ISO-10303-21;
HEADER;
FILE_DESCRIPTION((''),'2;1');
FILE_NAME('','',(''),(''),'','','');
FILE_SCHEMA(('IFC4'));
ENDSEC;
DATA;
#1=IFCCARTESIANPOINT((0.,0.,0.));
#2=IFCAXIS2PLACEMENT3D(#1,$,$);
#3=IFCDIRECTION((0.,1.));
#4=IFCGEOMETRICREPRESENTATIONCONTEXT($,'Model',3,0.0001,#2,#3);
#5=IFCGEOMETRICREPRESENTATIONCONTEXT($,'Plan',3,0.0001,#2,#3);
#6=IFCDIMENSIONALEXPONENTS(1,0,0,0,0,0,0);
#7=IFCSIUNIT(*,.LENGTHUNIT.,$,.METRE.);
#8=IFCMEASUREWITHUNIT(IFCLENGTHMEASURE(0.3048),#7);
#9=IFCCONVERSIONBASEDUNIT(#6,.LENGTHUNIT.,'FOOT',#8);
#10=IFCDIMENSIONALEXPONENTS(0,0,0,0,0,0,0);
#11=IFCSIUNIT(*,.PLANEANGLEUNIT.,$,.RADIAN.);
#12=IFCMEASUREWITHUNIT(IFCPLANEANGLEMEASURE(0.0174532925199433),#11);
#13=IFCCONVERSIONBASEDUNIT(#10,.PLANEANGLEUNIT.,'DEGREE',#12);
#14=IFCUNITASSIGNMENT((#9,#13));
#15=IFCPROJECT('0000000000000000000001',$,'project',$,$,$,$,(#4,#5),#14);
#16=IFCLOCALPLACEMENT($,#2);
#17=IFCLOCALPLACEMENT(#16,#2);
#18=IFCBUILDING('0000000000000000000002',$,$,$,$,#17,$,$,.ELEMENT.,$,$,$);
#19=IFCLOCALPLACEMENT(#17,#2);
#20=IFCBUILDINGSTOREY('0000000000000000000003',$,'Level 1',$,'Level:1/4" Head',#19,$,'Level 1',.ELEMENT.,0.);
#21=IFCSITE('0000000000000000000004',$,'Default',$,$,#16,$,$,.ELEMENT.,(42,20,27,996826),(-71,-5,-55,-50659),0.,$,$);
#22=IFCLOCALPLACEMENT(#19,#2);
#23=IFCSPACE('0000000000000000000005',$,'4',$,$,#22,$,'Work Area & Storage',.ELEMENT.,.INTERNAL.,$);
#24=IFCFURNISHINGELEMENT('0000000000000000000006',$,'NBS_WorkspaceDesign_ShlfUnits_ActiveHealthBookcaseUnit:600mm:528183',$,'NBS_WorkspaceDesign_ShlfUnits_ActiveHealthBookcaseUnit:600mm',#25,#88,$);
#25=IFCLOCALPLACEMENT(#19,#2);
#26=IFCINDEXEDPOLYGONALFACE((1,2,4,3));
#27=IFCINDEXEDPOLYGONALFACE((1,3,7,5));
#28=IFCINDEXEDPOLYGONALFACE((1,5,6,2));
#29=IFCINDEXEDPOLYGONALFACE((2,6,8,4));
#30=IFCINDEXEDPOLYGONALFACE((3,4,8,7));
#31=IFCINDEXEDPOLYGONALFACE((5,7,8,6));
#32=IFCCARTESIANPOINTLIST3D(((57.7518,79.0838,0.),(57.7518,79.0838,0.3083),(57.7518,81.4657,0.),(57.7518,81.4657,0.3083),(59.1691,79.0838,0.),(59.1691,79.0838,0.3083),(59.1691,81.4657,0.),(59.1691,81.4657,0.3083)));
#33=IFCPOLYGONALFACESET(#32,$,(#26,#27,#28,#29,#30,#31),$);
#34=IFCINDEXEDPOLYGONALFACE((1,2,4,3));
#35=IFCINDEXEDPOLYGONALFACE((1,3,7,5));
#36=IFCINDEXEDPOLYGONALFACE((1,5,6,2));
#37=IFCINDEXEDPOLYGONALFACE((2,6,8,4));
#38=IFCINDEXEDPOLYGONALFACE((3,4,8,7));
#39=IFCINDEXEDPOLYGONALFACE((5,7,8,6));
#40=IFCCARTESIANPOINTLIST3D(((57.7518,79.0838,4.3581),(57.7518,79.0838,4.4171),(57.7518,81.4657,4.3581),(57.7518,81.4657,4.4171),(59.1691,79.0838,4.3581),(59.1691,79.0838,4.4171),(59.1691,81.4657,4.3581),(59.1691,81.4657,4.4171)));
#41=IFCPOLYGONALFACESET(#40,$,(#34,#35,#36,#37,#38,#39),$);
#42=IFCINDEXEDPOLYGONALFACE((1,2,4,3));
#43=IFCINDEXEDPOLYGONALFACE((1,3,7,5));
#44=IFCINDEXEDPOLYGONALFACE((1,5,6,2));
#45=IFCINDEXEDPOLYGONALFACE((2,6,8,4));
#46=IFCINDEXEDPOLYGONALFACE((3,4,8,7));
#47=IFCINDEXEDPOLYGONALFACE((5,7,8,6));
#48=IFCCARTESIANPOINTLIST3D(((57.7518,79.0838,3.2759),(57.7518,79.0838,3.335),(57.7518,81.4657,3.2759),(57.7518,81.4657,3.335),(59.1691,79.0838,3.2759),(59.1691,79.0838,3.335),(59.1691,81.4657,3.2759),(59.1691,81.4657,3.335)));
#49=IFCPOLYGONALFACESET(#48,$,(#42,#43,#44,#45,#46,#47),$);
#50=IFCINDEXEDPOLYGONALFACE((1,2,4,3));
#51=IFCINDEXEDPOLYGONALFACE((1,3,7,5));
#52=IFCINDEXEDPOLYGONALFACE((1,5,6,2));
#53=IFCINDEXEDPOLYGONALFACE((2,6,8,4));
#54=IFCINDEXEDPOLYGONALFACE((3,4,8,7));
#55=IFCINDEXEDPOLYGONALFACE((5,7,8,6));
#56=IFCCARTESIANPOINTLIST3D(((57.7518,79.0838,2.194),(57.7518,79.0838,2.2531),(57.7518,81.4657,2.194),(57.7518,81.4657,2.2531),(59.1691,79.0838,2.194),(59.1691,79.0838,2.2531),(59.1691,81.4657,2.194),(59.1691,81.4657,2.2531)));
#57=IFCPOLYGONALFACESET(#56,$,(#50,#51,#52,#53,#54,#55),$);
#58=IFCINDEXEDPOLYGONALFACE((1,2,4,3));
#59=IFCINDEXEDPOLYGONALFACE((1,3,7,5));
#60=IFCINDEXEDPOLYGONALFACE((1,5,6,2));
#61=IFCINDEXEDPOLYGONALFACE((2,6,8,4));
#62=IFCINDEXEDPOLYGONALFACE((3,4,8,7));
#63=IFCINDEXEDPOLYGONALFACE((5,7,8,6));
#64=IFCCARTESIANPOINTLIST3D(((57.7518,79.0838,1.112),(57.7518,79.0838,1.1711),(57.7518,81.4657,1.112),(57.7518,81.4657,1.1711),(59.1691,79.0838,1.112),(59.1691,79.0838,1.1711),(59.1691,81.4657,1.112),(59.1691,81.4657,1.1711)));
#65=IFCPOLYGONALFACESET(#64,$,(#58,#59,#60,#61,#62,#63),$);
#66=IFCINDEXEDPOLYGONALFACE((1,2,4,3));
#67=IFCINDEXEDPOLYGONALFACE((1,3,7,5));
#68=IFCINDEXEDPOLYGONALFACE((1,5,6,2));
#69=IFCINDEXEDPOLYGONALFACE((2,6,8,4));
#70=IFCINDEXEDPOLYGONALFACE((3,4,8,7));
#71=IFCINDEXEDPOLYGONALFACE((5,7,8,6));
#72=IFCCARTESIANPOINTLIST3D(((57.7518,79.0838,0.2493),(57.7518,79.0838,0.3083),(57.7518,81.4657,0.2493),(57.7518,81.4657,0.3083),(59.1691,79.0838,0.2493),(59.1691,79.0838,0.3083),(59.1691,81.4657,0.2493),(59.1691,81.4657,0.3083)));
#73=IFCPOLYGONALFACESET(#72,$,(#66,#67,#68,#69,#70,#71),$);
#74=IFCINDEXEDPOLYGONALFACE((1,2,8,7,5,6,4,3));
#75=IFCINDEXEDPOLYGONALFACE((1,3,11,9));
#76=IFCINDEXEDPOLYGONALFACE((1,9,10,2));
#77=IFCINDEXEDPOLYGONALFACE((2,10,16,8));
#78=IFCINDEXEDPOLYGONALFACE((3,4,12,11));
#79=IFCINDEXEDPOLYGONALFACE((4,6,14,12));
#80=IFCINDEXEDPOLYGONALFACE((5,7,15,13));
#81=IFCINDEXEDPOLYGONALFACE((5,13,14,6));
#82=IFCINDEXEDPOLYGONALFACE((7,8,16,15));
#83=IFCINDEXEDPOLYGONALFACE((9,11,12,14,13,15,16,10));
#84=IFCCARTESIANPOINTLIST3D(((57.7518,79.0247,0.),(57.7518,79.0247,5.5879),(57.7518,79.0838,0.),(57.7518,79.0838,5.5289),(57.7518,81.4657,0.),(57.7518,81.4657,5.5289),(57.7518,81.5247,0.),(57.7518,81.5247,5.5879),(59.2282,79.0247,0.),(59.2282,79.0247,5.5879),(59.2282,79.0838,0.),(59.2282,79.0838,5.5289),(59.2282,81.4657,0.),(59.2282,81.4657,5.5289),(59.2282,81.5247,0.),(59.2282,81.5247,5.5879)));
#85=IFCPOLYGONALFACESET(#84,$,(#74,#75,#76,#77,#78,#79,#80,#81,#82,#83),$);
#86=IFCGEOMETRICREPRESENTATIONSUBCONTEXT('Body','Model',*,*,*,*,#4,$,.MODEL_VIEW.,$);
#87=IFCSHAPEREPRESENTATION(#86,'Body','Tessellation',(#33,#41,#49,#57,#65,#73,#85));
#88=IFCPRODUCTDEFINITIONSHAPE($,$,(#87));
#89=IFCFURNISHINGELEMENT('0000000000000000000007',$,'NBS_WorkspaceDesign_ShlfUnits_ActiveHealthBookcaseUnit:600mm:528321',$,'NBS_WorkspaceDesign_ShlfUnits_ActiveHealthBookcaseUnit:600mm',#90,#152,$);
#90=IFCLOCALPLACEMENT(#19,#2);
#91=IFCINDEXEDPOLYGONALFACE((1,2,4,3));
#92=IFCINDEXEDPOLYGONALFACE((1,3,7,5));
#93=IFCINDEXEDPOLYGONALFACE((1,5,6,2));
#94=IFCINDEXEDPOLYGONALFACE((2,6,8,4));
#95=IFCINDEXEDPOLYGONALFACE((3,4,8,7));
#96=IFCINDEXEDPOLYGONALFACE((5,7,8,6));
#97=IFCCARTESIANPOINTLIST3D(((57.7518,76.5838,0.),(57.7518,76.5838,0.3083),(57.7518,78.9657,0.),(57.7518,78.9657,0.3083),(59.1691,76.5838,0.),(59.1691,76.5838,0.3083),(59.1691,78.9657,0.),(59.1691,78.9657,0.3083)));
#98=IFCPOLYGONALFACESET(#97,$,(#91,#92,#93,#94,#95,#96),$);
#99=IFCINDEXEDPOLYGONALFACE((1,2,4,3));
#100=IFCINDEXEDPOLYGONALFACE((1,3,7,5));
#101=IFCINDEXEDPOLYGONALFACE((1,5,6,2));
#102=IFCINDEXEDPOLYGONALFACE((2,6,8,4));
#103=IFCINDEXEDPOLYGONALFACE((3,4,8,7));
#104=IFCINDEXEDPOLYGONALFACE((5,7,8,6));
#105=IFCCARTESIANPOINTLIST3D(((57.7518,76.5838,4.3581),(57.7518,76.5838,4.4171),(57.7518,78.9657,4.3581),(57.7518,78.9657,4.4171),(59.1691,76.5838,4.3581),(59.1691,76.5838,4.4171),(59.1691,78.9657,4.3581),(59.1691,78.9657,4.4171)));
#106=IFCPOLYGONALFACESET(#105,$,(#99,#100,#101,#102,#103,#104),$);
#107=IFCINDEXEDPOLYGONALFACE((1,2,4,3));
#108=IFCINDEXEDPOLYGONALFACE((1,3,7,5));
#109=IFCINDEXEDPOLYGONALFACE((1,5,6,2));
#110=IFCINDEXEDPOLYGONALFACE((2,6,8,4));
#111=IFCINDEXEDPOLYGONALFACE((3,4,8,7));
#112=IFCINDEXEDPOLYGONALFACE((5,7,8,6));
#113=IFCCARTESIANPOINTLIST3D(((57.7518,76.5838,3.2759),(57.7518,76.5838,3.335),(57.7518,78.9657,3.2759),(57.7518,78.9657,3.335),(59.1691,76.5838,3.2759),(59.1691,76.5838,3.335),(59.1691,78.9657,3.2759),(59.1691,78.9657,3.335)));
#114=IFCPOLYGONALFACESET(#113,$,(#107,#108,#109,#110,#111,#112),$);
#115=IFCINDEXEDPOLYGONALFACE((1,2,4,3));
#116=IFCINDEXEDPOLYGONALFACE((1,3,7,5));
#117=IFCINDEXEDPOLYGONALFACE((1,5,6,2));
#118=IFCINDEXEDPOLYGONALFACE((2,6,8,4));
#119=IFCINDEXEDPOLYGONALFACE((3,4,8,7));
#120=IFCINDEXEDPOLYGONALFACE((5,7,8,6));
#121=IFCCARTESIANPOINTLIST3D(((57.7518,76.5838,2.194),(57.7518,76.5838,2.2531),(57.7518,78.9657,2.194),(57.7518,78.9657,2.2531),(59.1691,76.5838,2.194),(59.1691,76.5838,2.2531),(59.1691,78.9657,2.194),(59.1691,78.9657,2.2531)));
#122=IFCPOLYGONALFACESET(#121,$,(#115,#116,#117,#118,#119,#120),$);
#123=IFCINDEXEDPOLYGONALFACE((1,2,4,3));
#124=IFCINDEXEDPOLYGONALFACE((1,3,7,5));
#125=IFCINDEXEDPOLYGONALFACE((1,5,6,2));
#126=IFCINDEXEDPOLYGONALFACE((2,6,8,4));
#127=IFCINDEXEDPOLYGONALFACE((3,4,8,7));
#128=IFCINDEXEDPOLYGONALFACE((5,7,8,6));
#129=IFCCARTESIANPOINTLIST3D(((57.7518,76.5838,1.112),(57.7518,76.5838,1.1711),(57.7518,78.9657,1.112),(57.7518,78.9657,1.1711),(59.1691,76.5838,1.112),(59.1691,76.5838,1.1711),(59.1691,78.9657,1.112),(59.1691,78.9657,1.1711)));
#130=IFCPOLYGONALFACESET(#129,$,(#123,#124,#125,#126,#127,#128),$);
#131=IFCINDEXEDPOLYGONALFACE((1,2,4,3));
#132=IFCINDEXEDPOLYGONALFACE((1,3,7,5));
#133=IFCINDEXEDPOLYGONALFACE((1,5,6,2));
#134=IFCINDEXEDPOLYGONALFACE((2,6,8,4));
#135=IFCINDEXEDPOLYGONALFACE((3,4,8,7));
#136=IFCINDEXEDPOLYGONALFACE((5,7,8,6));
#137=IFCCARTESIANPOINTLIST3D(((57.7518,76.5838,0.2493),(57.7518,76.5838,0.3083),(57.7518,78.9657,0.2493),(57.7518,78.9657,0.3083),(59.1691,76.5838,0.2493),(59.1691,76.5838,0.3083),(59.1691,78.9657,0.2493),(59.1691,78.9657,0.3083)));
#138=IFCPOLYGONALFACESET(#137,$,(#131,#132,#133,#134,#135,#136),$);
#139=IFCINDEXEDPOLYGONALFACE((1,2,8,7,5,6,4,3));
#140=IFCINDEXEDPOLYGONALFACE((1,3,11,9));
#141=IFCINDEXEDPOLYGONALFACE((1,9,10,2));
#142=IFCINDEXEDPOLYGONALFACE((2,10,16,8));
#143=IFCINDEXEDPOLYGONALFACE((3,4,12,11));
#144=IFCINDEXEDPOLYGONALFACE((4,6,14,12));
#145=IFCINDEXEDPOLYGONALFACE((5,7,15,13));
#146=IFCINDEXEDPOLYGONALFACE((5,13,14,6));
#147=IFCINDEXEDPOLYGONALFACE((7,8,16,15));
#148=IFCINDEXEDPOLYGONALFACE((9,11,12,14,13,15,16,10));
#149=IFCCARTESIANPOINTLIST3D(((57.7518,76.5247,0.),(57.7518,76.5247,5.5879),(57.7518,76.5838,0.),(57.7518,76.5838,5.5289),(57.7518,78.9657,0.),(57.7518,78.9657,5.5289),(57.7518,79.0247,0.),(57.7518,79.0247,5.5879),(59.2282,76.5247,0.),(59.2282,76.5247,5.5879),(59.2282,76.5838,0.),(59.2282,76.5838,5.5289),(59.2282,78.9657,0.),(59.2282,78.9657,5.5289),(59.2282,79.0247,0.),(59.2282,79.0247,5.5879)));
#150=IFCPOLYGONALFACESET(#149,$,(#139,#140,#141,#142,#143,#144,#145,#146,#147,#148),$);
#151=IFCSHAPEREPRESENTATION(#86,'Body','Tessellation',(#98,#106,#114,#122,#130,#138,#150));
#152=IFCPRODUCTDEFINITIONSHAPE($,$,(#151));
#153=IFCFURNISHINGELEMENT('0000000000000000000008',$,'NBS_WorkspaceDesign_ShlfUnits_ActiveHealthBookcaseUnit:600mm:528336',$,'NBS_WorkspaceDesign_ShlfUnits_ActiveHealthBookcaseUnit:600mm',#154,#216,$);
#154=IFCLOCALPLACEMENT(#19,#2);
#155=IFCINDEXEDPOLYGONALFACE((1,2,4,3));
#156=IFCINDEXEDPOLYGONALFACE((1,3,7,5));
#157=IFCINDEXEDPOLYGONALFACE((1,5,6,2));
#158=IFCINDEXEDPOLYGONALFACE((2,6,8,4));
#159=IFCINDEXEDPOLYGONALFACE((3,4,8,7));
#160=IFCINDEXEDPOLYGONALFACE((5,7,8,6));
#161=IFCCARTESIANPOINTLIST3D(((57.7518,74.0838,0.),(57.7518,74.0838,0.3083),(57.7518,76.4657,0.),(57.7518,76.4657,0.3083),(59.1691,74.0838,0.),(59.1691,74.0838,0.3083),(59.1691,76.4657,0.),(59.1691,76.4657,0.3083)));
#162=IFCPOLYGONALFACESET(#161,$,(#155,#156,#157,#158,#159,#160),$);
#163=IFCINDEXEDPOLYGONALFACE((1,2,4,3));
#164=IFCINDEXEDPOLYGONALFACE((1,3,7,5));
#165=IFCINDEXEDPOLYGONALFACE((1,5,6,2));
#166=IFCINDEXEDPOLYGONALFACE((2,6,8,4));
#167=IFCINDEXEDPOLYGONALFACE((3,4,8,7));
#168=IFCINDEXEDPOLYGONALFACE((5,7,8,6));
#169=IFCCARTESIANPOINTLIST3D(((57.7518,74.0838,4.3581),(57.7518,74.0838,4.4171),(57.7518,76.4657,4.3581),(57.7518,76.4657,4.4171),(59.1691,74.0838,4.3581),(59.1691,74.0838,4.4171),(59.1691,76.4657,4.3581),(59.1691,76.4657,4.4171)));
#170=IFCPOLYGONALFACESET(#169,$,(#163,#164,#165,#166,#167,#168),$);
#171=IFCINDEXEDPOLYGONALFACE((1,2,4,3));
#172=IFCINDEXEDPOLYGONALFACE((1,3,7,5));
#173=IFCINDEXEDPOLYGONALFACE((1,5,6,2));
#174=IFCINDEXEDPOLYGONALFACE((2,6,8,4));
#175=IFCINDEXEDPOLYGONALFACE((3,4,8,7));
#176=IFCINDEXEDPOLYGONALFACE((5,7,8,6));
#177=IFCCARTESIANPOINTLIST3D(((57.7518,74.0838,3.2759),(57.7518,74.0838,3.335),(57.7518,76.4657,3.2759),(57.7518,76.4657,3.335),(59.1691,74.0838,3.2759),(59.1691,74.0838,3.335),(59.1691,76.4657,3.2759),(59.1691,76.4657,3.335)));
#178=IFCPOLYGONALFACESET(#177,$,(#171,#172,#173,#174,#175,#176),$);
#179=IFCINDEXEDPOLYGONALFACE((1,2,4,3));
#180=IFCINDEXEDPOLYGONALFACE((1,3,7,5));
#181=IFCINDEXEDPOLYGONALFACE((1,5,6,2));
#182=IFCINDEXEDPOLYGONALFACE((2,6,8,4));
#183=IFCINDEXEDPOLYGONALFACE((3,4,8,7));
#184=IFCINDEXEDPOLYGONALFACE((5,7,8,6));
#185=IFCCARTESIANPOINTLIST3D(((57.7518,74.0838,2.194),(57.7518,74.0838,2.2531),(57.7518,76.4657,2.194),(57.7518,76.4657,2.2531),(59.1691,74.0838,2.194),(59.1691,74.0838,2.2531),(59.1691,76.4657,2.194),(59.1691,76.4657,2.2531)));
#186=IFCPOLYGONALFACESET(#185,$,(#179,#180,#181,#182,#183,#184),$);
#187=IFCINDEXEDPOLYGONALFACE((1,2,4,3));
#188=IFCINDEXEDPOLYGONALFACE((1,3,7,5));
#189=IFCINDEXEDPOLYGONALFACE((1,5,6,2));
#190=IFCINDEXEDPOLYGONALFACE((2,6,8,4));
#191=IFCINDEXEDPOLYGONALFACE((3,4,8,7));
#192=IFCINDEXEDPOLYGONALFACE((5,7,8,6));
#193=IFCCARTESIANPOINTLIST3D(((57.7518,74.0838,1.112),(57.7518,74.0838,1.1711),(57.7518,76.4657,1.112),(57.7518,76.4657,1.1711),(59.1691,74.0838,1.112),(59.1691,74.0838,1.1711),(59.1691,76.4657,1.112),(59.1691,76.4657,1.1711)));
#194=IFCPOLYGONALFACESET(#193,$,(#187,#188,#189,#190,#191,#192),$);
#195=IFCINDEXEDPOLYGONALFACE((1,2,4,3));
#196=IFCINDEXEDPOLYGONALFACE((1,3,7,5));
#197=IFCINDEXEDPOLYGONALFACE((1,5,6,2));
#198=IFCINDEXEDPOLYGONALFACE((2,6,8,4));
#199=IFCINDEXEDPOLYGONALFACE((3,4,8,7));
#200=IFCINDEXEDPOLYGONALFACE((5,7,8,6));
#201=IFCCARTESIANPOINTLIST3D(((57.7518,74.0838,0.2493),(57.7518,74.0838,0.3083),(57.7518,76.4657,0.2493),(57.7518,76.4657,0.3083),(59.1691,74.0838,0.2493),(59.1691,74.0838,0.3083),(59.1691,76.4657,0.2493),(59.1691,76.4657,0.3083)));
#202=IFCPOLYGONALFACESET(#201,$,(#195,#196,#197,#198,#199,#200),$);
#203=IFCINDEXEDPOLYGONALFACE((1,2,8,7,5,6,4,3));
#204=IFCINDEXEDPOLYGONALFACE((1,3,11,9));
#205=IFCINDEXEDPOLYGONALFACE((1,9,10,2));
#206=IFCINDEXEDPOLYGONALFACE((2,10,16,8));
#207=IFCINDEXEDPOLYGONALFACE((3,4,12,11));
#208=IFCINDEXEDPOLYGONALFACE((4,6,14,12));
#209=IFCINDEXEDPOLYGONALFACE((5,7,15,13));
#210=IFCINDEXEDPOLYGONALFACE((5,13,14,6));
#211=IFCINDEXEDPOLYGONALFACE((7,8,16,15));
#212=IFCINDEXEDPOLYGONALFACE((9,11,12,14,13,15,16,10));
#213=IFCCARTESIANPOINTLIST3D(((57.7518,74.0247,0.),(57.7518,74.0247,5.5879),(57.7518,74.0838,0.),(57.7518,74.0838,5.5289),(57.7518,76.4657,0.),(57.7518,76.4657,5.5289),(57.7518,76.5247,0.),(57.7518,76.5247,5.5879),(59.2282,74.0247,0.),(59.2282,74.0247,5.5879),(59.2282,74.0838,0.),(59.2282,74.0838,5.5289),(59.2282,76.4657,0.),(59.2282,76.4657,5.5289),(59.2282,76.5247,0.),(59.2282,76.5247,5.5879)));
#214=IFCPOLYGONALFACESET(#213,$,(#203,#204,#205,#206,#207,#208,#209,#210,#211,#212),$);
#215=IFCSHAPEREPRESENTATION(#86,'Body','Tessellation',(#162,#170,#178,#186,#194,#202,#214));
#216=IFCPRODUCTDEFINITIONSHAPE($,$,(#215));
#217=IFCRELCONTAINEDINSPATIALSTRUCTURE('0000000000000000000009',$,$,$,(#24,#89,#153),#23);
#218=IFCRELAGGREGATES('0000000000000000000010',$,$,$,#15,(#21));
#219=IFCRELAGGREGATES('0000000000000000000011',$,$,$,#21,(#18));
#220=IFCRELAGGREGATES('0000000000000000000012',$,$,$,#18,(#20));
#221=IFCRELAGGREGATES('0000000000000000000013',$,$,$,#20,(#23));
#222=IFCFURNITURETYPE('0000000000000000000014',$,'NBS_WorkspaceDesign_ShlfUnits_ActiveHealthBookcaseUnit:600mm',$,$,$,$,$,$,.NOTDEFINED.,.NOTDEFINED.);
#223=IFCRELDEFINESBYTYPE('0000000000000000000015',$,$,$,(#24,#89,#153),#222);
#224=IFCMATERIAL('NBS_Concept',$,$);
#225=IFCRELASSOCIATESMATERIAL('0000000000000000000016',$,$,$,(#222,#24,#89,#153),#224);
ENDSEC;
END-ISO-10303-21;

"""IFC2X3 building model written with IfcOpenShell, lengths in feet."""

from ifc_helpers import new_model, entity, si_unit, converted_unit, direction, frame, frame_2d, origin, place, context, subcontext, project, spatial, polyline, rectangle, outline, extrude, source, transform, mapped, material, type_object, type_shapes, element, save


model = new_model("IFC2X3")

# Units and contexts
model_context = context("Model", 3, precision=0.0001, world=origin(), true_north=direction((0.0, 1.0)))
plan_context = context("Plan", 3, precision=0.0001, world=origin(), true_north=direction((0.0, 1.0)))
body_context = subcontext(model_context, "Body", "Model", "MODEL_VIEW")
ifc_project = project(units=[converted_unit("LENGTHUNIT", "FOOT", entity("IfcLengthMeasure", 0.3048), si_unit("LENGTHUNIT", "METRE"), dimensions=[1, 0, 0, 0, 0, 0, 0]), converted_unit("PLANEANGLEUNIT", "DEGREE", entity("IfcPlaneAngleMeasure", 0.0174532925199433), si_unit("PLANEANGLEUNIT", "RADIAN"), dimensions=[0, 0, 0, 0, 0, 0, 0])], contexts=[model_context, plan_context])

# Site, building, storey
site_placement = place(None, origin())
site = spatial("IfcSite", under=ifc_project, at=site_placement, Name="Default", CompositionType="ELEMENT", RefLatitude=(42, 20, 27, 996826), RefLongitude=(-71, -5, -55, -50659), RefElevation=0.0)
building_placement = place(site_placement, origin())
building = spatial("IfcBuilding", under=site, at=building_placement, CompositionType="ELEMENT")
storey_placement = place(building_placement, origin())
storey = spatial("IfcBuildingStorey", under=building, at=storey_placement, Name="Level 1", ObjectType="Level:1/4\" Head", LongName="Level 1", CompositionType="ELEMENT", Elevation=0.0)

# Shared definitions
space_1_placement = place(storey_placement, origin())
space_1 = spatial("IfcSpace", under=storey, at=space_1_placement, Name="4", LongName="Work Area & Storage", CompositionType="ELEMENT", InteriorOrExteriorSpace="INTERNAL")

# Furnishing elements
ifc_material_1 = material(Name="NBS_Concept")
furniture_type_1 = type_object("IfcFurnitureType", Name="NBS_WorkspaceDesign_ShlfUnits_ActiveHealthBookcaseUnit:600mm", AssemblyPlace="NOTDEFINED", material=ifc_material_1)
shared_shape_1 = source(origin(), body_context, "Body", "SweptSolid", [
    extrude(rectangle(XDim=1.4173, YDim=2.3819, at=frame_2d((0.0, 0.0), x_axis=(1.0, 0.0))), frame((0.0, -0.7677, 0.0), z_axis=(0.0, 0.0, 1.0), x_axis=(0.0, 1.0, 0.0)), (0.0, 0.0, 1.0), 0.3083),
    extrude(rectangle(XDim=1.4173, YDim=2.3819, at=frame_2d((0.0, 0.0), x_axis=(1.0, 0.0))), frame((0.0, -0.7677, 4.3581), z_axis=(0.0, 0.0, 1.0), x_axis=(0.0, 1.0, 0.0)), (0.0, 0.0, 1.0), 0.0591),
    extrude(rectangle(XDim=1.4173, YDim=2.3819, at=frame_2d((0.0, 0.0), x_axis=(1.0, 0.0))), frame((0.0, -0.7677, 3.2759), z_axis=(0.0, 0.0, 1.0), x_axis=(0.0, 1.0, 0.0)), (0.0, 0.0, 1.0), 0.0591),
    extrude(rectangle(XDim=1.4173, YDim=2.3819, at=frame_2d((0.0, 0.0), x_axis=(1.0, 0.0))), frame((0.0, -0.7677, 2.194), z_axis=(0.0, 0.0, 1.0), x_axis=(0.0, 1.0, 0.0)), (0.0, 0.0, 1.0), 0.0591),
    extrude(rectangle(XDim=1.4173, YDim=2.3819, at=frame_2d((0.0, 0.0), x_axis=(1.0, 0.0))), frame((0.0, -0.7677, 1.112), z_axis=(0.0, 0.0, 1.0), x_axis=(0.0, 1.0, 0.0)), (0.0, 0.0, 1.0), 0.0591),
    extrude(rectangle(XDim=1.4173, YDim=2.3819, at=frame_2d((0.0, 0.0), x_axis=(1.0, 0.0))), frame((0.0, -0.7677, 0.2493), z_axis=(0.0, 0.0, 1.0), x_axis=(0.0, 1.0, 0.0)), (0.0, 0.0, 1.0), 0.0591),
    extrude(outline(polyline([(-2.8087, -1.25), (2.7792, -1.25), (2.7792, -1.1909), (-2.7497, -1.1909), (-2.7497, 1.1909), (2.7792, 1.1909), (2.7792, 1.25), (-2.8087, 1.25), (-2.8087, -1.25)])), frame((0.0, -1.4764, 2.7792), z_axis=(0.0, 1.0, 0.0), x_axis=(0.0, 0.0, -1.0)), (0.0, 0.0, 1.0), 1.4764),
])
type_shapes(furniture_type_1, [shared_shape_1])
for number, where, z_axis, x_axis, name in (
    (1, (59.2282, 80.2747, 0.0), (0.0, 0.0, 1.0), (0.0, -1.0, 0.0), "NBS_WorkspaceDesign_ShlfUnits_ActiveHealthBookcaseUnit:600mm:528183"),
    (2, (59.2282, 77.7747, 0.0), (0.0, 0.0, 1.0), (0.0, -1.0, 0.0), "NBS_WorkspaceDesign_ShlfUnits_ActiveHealthBookcaseUnit:600mm:528321"),
    (3, (59.2282, 75.2747, 0.0), (0.0, 0.0, 1.0), (0.0, -1.0, 0.0), "NBS_WorkspaceDesign_ShlfUnits_ActiveHealthBookcaseUnit:600mm:528336"),
):
    element("IfcFurnishingElement", number, at=place(space_1_placement, frame(where, z_axis=z_axis, x_axis=x_axis)), inside=space_1, type_object=furniture_type_1, material=ifc_material_1, Name=name, ObjectType="NBS_WorkspaceDesign_ShlfUnits_ActiveHealthBookcaseUnit:600mm", context=body_context, shape_type="MappedRepresentation", body=[
        mapped(shared_shape_1, transform((0.0, 0.0, 0.0), scale=1.0)),
    ])

save(model, "model.ifc")
